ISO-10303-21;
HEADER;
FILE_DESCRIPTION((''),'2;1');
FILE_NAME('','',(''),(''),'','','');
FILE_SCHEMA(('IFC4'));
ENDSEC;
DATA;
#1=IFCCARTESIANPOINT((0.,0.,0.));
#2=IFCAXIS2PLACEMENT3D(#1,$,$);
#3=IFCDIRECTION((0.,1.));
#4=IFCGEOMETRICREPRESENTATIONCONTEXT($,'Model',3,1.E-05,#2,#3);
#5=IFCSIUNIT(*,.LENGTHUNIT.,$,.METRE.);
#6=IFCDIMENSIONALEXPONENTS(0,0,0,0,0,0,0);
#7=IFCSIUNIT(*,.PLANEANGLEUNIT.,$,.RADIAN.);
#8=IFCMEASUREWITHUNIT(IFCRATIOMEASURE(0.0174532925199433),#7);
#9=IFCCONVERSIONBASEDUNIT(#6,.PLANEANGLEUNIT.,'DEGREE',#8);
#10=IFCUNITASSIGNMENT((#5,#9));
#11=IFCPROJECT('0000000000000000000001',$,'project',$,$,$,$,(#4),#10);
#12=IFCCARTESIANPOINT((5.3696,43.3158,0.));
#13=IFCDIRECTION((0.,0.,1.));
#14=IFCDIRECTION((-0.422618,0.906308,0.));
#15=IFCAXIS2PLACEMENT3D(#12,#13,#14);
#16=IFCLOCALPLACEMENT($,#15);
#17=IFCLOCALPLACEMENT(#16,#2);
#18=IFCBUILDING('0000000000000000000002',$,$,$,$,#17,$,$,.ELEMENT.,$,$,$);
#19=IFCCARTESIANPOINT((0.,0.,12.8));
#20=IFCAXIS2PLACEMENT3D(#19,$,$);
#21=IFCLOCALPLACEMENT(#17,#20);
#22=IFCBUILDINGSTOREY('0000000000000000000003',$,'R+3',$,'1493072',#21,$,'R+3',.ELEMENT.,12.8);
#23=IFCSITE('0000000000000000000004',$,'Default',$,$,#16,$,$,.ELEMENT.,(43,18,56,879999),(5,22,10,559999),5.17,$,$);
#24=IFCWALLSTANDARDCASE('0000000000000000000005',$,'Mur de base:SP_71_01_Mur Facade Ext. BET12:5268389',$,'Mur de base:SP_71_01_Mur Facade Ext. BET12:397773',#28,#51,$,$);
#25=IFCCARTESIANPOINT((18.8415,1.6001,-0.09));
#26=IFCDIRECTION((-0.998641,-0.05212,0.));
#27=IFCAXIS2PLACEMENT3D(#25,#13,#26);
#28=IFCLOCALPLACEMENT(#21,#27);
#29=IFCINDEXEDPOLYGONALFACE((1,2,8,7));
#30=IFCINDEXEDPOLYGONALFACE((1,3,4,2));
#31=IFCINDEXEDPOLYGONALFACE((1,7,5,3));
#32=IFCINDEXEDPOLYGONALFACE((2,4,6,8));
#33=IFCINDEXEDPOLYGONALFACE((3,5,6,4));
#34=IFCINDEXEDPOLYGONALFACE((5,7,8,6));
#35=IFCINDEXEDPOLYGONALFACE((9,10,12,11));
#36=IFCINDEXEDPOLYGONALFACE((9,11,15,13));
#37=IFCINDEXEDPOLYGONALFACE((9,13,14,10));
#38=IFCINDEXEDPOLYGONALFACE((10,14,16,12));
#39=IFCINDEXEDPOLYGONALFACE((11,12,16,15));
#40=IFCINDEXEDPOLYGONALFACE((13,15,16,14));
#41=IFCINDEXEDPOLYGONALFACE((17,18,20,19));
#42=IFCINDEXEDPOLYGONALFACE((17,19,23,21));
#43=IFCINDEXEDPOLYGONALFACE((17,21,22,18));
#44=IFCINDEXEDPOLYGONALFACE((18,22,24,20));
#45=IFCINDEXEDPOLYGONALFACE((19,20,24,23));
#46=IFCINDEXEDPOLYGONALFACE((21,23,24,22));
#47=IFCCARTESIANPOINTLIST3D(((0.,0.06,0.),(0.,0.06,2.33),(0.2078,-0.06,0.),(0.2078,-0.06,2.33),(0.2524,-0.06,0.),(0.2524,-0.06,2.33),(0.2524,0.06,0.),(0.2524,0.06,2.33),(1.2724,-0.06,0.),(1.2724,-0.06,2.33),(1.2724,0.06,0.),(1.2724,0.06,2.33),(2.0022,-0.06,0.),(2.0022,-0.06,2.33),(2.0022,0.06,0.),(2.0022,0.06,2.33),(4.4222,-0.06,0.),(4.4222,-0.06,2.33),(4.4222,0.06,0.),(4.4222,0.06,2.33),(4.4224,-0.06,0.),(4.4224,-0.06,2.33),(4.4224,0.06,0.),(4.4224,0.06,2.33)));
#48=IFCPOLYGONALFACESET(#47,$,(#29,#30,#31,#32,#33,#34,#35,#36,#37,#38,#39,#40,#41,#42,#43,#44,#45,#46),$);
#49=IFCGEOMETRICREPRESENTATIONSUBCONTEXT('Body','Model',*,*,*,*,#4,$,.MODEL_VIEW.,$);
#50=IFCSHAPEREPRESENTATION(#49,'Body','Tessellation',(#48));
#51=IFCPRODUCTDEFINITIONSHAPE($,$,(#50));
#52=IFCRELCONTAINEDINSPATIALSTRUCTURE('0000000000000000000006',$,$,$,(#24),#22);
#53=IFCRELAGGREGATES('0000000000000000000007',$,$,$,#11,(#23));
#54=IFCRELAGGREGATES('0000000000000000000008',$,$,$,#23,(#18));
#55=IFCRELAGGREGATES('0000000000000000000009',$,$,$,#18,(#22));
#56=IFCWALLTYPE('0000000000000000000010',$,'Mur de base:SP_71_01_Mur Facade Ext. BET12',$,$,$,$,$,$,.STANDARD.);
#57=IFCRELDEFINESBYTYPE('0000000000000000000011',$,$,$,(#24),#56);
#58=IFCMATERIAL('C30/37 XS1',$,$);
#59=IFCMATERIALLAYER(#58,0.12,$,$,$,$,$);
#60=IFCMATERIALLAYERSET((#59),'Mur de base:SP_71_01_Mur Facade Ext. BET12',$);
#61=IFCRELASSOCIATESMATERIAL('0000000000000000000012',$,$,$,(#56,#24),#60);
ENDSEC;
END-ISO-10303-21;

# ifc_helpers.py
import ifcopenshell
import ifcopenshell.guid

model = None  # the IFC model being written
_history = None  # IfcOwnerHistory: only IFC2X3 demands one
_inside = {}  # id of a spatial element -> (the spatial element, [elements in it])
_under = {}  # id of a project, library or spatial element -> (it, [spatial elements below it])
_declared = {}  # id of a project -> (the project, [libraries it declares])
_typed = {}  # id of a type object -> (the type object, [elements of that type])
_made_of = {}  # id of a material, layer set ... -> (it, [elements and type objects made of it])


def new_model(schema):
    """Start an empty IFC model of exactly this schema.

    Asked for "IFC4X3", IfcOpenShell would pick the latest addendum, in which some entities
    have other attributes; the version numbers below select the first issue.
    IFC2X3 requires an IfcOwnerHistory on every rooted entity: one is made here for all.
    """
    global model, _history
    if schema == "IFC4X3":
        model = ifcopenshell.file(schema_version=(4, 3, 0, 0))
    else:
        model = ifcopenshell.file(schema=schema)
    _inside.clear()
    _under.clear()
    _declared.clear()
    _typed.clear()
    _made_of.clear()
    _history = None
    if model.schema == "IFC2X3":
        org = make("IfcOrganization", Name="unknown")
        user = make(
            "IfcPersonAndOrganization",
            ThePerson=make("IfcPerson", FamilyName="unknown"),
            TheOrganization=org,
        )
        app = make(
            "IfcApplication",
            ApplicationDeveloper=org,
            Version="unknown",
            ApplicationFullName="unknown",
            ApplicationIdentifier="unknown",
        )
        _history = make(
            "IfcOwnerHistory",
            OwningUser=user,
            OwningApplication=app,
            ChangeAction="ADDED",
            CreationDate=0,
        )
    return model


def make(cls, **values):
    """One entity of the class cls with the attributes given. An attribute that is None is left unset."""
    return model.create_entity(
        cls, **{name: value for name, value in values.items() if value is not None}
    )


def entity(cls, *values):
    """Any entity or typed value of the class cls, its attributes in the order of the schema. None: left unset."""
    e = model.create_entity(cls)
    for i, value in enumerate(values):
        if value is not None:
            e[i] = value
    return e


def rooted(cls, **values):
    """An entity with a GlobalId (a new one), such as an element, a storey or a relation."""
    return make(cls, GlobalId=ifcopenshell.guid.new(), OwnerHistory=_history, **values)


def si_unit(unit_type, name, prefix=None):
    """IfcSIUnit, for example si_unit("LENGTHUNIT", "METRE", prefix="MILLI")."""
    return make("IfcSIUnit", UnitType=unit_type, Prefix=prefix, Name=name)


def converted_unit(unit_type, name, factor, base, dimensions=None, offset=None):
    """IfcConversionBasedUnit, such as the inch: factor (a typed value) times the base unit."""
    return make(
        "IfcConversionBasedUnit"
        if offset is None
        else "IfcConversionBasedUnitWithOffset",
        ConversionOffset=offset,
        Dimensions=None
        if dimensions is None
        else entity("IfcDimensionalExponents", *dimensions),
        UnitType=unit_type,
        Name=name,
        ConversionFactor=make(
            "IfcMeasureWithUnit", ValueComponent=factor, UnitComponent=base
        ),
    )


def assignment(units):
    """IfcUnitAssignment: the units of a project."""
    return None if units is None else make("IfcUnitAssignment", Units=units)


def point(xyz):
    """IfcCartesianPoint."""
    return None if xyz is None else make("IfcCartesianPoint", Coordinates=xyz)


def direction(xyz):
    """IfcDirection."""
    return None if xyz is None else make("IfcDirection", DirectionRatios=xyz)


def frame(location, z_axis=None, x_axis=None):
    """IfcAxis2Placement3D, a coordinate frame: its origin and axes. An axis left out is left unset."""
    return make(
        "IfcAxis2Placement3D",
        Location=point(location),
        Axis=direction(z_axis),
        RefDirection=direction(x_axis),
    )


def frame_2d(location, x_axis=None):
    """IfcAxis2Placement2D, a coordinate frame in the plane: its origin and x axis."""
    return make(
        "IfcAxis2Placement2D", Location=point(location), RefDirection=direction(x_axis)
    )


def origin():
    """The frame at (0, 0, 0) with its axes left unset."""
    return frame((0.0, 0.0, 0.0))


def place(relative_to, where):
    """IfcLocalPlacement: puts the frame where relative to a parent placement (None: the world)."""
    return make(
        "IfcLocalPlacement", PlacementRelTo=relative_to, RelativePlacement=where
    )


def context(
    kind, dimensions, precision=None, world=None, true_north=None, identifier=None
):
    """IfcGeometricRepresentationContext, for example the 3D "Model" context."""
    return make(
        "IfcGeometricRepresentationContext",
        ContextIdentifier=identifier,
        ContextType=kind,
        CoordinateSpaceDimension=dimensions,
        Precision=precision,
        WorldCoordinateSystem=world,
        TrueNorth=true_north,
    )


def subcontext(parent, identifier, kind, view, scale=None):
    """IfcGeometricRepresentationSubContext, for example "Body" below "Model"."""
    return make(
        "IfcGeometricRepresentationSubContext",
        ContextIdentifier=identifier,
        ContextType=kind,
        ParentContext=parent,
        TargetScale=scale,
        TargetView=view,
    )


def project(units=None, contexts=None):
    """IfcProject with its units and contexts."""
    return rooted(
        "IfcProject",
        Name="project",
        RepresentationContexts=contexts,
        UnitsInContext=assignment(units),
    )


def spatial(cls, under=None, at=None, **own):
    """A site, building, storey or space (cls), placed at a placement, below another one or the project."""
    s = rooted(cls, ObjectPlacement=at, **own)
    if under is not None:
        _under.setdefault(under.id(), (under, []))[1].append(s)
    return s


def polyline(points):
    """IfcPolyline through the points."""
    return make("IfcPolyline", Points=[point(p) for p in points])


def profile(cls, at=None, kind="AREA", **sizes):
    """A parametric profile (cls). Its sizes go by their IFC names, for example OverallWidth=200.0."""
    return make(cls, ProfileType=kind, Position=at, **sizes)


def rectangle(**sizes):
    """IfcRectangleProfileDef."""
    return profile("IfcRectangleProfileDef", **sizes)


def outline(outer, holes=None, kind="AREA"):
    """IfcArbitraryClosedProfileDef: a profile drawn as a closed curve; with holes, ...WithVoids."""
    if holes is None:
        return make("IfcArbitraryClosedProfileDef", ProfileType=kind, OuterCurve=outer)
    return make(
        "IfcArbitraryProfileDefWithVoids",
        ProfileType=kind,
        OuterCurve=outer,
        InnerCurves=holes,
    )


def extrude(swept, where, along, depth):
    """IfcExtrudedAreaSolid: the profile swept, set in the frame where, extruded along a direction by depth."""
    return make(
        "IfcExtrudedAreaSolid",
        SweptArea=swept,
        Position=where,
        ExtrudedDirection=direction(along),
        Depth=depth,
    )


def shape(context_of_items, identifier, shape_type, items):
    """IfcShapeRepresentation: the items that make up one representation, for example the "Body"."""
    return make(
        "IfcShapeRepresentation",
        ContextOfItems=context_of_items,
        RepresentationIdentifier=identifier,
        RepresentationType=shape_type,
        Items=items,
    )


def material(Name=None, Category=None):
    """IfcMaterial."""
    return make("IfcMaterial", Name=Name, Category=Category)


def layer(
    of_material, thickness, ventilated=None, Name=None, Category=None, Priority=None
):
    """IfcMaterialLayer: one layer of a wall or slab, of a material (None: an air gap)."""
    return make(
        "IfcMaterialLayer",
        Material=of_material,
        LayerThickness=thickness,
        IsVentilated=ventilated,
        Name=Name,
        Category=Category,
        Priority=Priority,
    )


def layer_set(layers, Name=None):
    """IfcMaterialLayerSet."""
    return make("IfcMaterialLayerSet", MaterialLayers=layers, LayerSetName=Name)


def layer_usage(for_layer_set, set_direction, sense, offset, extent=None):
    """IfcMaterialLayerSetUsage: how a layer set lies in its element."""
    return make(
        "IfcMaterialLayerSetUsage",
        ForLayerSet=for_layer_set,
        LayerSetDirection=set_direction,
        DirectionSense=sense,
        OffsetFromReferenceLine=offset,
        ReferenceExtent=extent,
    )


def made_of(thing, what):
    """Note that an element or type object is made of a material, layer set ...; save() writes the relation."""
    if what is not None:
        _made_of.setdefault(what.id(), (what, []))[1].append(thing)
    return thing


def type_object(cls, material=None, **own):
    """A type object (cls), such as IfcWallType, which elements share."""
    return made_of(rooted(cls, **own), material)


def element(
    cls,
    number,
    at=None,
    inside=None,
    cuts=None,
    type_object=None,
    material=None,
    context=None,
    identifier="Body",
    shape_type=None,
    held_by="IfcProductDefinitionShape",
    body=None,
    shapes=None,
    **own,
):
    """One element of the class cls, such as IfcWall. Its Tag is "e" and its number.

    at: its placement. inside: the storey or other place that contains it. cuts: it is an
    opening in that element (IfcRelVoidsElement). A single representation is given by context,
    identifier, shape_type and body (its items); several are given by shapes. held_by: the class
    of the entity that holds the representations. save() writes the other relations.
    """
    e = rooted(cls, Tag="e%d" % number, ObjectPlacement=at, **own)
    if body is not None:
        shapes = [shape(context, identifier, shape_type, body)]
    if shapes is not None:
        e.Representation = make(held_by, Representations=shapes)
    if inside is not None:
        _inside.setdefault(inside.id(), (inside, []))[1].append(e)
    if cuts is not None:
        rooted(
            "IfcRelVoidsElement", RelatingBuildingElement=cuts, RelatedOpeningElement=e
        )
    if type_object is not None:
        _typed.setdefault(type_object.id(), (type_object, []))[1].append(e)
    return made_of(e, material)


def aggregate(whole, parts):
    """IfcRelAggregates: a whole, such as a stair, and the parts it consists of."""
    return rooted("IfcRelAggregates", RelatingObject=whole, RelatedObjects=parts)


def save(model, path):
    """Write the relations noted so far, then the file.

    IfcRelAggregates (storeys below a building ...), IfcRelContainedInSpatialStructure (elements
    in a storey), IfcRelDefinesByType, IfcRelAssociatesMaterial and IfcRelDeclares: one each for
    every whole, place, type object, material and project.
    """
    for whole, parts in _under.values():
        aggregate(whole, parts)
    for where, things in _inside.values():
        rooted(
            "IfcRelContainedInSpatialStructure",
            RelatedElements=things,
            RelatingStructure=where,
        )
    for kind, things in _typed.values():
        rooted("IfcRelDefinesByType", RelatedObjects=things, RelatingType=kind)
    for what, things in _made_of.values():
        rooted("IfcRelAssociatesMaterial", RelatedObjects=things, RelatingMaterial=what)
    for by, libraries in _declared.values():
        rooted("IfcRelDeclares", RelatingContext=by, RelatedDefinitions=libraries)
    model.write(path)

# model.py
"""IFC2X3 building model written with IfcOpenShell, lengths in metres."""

from ifc_helpers import new_model, entity, si_unit, converted_unit, direction, frame, frame_2d, origin, place, context, subcontext, project, spatial, polyline, rectangle, outline, extrude, material, layer, layer_set, layer_usage, type_object, element, save


model = new_model("IFC2X3")

# Units and contexts
model_context = context("Model", 3, precision=1e-05, world=origin(), true_north=direction((0.0, 1.0)))
body_context = subcontext(model_context, "Body", "Model", "MODEL_VIEW")
ifc_project = project(units=[si_unit("LENGTHUNIT", "METRE"), converted_unit("PLANEANGLEUNIT", "DEGREE", entity("IfcRatioMeasure", 0.0174532925199433), si_unit("PLANEANGLEUNIT", "RADIAN"), dimensions=[0, 0, 0, 0, 0, 0, 0])], contexts=[model_context])

# Site, building, storey
site_placement = place(None, frame((5.3696, 43.3158, 0.0), z_axis=(0.0, 0.0, 1.0), x_axis=(-0.422618, 0.906308, 0.0)))
site = spatial("IfcSite", under=ifc_project, at=site_placement, Name="Default", CompositionType="ELEMENT", RefLatitude=(43, 18, 56, 879999), RefLongitude=(5, 22, 10, 559999), RefElevation=5.17)
building_placement = place(site_placement, origin())
building = spatial("IfcBuilding", under=site, at=building_placement, CompositionType="ELEMENT")
storey_placement = place(building_placement, frame((0.0, 0.0, 12.8)))
storey = spatial("IfcBuildingStorey", under=building, at=storey_placement, Name="R+3", ObjectType="1493072", LongName="R+3", CompositionType="ELEMENT", Elevation=12.8)

# Shared definitions
ifc_material = material(Name="C30/37 XS1")

# Wall, openings
ifc_layer_1 = layer(ifc_material, 0.12)
ifc_layer_set_1 = layer_set([ifc_layer_1], Name="Mur de base:SP_71_01_Mur Facade Ext. BET12")
ifc_layer_usage_1 = layer_usage(ifc_layer_set_1, "AXIS2", "NEGATIVE", 0.06)
wall_type_1 = type_object("IfcWallType", Name="Mur de base:SP_71_01_Mur Facade Ext. BET12", PredefinedType="STANDARD", material=ifc_layer_set_1)
wall_1_placement = place(storey_placement, frame((18.8415, 1.6001, -0.09), z_axis=(0.0, 0.0, 1.0), x_axis=(-0.998641, -0.05212, 0.0)))
wall_1 = element("IfcWallStandardCase", 1, at=wall_1_placement, inside=storey, type_object=wall_type_1, material=ifc_layer_usage_1, Name="Mur de base:SP_71_01_Mur Facade Ext. BET12:5268389", ObjectType="Mur de base:SP_71_01_Mur Facade Ext. BET12:397773", context=body_context, shape_type="SweptSolid", body=[
    extrude(outline(polyline([(0.2078, -0.06), (4.4224, -0.06), (4.4224, 0.06), (0.0, 0.06), (0.2078, -0.06)])), origin(), (0.0, 0.0, 1.0), 2.33),
])
opening_1_placement = place(wall_1_placement, origin())
element("IfcOpeningElement", 2, at=opening_1_placement, cuts=wall_1, ObjectType="Opening", context=body_context, shape_type="SweptSolid", body=[
    extrude(rectangle(XDim=2.33, YDim=2.42, at=frame_2d((0.0, 0.0), x_axis=(0.0, 1.0))), frame((3.2122, -1.584, 1.165), z_axis=(0.0, 1.0, 0.0), x_axis=(1.0, 0.0, 0.0)), (0.0, 0.0, 1.0), 3.048),
])
opening_2_placement = place(wall_1_placement, origin())
element("IfcOpeningElement", 3, at=opening_2_placement, cuts=wall_1, ObjectType="Opening", context=body_context, shape_type="SweptSolid", body=[
    extrude(rectangle(XDim=2.33, YDim=1.02, at=frame_2d((0.0, 0.0), x_axis=(0.0, 1.0))), frame((0.7624, -1.584, 1.165), z_axis=(0.0, 1.0, 0.0), x_axis=(1.0, 0.0, 0.0)), (0.0, 0.0, 1.0), 3.048),
])

save(model, "model.ifc")
